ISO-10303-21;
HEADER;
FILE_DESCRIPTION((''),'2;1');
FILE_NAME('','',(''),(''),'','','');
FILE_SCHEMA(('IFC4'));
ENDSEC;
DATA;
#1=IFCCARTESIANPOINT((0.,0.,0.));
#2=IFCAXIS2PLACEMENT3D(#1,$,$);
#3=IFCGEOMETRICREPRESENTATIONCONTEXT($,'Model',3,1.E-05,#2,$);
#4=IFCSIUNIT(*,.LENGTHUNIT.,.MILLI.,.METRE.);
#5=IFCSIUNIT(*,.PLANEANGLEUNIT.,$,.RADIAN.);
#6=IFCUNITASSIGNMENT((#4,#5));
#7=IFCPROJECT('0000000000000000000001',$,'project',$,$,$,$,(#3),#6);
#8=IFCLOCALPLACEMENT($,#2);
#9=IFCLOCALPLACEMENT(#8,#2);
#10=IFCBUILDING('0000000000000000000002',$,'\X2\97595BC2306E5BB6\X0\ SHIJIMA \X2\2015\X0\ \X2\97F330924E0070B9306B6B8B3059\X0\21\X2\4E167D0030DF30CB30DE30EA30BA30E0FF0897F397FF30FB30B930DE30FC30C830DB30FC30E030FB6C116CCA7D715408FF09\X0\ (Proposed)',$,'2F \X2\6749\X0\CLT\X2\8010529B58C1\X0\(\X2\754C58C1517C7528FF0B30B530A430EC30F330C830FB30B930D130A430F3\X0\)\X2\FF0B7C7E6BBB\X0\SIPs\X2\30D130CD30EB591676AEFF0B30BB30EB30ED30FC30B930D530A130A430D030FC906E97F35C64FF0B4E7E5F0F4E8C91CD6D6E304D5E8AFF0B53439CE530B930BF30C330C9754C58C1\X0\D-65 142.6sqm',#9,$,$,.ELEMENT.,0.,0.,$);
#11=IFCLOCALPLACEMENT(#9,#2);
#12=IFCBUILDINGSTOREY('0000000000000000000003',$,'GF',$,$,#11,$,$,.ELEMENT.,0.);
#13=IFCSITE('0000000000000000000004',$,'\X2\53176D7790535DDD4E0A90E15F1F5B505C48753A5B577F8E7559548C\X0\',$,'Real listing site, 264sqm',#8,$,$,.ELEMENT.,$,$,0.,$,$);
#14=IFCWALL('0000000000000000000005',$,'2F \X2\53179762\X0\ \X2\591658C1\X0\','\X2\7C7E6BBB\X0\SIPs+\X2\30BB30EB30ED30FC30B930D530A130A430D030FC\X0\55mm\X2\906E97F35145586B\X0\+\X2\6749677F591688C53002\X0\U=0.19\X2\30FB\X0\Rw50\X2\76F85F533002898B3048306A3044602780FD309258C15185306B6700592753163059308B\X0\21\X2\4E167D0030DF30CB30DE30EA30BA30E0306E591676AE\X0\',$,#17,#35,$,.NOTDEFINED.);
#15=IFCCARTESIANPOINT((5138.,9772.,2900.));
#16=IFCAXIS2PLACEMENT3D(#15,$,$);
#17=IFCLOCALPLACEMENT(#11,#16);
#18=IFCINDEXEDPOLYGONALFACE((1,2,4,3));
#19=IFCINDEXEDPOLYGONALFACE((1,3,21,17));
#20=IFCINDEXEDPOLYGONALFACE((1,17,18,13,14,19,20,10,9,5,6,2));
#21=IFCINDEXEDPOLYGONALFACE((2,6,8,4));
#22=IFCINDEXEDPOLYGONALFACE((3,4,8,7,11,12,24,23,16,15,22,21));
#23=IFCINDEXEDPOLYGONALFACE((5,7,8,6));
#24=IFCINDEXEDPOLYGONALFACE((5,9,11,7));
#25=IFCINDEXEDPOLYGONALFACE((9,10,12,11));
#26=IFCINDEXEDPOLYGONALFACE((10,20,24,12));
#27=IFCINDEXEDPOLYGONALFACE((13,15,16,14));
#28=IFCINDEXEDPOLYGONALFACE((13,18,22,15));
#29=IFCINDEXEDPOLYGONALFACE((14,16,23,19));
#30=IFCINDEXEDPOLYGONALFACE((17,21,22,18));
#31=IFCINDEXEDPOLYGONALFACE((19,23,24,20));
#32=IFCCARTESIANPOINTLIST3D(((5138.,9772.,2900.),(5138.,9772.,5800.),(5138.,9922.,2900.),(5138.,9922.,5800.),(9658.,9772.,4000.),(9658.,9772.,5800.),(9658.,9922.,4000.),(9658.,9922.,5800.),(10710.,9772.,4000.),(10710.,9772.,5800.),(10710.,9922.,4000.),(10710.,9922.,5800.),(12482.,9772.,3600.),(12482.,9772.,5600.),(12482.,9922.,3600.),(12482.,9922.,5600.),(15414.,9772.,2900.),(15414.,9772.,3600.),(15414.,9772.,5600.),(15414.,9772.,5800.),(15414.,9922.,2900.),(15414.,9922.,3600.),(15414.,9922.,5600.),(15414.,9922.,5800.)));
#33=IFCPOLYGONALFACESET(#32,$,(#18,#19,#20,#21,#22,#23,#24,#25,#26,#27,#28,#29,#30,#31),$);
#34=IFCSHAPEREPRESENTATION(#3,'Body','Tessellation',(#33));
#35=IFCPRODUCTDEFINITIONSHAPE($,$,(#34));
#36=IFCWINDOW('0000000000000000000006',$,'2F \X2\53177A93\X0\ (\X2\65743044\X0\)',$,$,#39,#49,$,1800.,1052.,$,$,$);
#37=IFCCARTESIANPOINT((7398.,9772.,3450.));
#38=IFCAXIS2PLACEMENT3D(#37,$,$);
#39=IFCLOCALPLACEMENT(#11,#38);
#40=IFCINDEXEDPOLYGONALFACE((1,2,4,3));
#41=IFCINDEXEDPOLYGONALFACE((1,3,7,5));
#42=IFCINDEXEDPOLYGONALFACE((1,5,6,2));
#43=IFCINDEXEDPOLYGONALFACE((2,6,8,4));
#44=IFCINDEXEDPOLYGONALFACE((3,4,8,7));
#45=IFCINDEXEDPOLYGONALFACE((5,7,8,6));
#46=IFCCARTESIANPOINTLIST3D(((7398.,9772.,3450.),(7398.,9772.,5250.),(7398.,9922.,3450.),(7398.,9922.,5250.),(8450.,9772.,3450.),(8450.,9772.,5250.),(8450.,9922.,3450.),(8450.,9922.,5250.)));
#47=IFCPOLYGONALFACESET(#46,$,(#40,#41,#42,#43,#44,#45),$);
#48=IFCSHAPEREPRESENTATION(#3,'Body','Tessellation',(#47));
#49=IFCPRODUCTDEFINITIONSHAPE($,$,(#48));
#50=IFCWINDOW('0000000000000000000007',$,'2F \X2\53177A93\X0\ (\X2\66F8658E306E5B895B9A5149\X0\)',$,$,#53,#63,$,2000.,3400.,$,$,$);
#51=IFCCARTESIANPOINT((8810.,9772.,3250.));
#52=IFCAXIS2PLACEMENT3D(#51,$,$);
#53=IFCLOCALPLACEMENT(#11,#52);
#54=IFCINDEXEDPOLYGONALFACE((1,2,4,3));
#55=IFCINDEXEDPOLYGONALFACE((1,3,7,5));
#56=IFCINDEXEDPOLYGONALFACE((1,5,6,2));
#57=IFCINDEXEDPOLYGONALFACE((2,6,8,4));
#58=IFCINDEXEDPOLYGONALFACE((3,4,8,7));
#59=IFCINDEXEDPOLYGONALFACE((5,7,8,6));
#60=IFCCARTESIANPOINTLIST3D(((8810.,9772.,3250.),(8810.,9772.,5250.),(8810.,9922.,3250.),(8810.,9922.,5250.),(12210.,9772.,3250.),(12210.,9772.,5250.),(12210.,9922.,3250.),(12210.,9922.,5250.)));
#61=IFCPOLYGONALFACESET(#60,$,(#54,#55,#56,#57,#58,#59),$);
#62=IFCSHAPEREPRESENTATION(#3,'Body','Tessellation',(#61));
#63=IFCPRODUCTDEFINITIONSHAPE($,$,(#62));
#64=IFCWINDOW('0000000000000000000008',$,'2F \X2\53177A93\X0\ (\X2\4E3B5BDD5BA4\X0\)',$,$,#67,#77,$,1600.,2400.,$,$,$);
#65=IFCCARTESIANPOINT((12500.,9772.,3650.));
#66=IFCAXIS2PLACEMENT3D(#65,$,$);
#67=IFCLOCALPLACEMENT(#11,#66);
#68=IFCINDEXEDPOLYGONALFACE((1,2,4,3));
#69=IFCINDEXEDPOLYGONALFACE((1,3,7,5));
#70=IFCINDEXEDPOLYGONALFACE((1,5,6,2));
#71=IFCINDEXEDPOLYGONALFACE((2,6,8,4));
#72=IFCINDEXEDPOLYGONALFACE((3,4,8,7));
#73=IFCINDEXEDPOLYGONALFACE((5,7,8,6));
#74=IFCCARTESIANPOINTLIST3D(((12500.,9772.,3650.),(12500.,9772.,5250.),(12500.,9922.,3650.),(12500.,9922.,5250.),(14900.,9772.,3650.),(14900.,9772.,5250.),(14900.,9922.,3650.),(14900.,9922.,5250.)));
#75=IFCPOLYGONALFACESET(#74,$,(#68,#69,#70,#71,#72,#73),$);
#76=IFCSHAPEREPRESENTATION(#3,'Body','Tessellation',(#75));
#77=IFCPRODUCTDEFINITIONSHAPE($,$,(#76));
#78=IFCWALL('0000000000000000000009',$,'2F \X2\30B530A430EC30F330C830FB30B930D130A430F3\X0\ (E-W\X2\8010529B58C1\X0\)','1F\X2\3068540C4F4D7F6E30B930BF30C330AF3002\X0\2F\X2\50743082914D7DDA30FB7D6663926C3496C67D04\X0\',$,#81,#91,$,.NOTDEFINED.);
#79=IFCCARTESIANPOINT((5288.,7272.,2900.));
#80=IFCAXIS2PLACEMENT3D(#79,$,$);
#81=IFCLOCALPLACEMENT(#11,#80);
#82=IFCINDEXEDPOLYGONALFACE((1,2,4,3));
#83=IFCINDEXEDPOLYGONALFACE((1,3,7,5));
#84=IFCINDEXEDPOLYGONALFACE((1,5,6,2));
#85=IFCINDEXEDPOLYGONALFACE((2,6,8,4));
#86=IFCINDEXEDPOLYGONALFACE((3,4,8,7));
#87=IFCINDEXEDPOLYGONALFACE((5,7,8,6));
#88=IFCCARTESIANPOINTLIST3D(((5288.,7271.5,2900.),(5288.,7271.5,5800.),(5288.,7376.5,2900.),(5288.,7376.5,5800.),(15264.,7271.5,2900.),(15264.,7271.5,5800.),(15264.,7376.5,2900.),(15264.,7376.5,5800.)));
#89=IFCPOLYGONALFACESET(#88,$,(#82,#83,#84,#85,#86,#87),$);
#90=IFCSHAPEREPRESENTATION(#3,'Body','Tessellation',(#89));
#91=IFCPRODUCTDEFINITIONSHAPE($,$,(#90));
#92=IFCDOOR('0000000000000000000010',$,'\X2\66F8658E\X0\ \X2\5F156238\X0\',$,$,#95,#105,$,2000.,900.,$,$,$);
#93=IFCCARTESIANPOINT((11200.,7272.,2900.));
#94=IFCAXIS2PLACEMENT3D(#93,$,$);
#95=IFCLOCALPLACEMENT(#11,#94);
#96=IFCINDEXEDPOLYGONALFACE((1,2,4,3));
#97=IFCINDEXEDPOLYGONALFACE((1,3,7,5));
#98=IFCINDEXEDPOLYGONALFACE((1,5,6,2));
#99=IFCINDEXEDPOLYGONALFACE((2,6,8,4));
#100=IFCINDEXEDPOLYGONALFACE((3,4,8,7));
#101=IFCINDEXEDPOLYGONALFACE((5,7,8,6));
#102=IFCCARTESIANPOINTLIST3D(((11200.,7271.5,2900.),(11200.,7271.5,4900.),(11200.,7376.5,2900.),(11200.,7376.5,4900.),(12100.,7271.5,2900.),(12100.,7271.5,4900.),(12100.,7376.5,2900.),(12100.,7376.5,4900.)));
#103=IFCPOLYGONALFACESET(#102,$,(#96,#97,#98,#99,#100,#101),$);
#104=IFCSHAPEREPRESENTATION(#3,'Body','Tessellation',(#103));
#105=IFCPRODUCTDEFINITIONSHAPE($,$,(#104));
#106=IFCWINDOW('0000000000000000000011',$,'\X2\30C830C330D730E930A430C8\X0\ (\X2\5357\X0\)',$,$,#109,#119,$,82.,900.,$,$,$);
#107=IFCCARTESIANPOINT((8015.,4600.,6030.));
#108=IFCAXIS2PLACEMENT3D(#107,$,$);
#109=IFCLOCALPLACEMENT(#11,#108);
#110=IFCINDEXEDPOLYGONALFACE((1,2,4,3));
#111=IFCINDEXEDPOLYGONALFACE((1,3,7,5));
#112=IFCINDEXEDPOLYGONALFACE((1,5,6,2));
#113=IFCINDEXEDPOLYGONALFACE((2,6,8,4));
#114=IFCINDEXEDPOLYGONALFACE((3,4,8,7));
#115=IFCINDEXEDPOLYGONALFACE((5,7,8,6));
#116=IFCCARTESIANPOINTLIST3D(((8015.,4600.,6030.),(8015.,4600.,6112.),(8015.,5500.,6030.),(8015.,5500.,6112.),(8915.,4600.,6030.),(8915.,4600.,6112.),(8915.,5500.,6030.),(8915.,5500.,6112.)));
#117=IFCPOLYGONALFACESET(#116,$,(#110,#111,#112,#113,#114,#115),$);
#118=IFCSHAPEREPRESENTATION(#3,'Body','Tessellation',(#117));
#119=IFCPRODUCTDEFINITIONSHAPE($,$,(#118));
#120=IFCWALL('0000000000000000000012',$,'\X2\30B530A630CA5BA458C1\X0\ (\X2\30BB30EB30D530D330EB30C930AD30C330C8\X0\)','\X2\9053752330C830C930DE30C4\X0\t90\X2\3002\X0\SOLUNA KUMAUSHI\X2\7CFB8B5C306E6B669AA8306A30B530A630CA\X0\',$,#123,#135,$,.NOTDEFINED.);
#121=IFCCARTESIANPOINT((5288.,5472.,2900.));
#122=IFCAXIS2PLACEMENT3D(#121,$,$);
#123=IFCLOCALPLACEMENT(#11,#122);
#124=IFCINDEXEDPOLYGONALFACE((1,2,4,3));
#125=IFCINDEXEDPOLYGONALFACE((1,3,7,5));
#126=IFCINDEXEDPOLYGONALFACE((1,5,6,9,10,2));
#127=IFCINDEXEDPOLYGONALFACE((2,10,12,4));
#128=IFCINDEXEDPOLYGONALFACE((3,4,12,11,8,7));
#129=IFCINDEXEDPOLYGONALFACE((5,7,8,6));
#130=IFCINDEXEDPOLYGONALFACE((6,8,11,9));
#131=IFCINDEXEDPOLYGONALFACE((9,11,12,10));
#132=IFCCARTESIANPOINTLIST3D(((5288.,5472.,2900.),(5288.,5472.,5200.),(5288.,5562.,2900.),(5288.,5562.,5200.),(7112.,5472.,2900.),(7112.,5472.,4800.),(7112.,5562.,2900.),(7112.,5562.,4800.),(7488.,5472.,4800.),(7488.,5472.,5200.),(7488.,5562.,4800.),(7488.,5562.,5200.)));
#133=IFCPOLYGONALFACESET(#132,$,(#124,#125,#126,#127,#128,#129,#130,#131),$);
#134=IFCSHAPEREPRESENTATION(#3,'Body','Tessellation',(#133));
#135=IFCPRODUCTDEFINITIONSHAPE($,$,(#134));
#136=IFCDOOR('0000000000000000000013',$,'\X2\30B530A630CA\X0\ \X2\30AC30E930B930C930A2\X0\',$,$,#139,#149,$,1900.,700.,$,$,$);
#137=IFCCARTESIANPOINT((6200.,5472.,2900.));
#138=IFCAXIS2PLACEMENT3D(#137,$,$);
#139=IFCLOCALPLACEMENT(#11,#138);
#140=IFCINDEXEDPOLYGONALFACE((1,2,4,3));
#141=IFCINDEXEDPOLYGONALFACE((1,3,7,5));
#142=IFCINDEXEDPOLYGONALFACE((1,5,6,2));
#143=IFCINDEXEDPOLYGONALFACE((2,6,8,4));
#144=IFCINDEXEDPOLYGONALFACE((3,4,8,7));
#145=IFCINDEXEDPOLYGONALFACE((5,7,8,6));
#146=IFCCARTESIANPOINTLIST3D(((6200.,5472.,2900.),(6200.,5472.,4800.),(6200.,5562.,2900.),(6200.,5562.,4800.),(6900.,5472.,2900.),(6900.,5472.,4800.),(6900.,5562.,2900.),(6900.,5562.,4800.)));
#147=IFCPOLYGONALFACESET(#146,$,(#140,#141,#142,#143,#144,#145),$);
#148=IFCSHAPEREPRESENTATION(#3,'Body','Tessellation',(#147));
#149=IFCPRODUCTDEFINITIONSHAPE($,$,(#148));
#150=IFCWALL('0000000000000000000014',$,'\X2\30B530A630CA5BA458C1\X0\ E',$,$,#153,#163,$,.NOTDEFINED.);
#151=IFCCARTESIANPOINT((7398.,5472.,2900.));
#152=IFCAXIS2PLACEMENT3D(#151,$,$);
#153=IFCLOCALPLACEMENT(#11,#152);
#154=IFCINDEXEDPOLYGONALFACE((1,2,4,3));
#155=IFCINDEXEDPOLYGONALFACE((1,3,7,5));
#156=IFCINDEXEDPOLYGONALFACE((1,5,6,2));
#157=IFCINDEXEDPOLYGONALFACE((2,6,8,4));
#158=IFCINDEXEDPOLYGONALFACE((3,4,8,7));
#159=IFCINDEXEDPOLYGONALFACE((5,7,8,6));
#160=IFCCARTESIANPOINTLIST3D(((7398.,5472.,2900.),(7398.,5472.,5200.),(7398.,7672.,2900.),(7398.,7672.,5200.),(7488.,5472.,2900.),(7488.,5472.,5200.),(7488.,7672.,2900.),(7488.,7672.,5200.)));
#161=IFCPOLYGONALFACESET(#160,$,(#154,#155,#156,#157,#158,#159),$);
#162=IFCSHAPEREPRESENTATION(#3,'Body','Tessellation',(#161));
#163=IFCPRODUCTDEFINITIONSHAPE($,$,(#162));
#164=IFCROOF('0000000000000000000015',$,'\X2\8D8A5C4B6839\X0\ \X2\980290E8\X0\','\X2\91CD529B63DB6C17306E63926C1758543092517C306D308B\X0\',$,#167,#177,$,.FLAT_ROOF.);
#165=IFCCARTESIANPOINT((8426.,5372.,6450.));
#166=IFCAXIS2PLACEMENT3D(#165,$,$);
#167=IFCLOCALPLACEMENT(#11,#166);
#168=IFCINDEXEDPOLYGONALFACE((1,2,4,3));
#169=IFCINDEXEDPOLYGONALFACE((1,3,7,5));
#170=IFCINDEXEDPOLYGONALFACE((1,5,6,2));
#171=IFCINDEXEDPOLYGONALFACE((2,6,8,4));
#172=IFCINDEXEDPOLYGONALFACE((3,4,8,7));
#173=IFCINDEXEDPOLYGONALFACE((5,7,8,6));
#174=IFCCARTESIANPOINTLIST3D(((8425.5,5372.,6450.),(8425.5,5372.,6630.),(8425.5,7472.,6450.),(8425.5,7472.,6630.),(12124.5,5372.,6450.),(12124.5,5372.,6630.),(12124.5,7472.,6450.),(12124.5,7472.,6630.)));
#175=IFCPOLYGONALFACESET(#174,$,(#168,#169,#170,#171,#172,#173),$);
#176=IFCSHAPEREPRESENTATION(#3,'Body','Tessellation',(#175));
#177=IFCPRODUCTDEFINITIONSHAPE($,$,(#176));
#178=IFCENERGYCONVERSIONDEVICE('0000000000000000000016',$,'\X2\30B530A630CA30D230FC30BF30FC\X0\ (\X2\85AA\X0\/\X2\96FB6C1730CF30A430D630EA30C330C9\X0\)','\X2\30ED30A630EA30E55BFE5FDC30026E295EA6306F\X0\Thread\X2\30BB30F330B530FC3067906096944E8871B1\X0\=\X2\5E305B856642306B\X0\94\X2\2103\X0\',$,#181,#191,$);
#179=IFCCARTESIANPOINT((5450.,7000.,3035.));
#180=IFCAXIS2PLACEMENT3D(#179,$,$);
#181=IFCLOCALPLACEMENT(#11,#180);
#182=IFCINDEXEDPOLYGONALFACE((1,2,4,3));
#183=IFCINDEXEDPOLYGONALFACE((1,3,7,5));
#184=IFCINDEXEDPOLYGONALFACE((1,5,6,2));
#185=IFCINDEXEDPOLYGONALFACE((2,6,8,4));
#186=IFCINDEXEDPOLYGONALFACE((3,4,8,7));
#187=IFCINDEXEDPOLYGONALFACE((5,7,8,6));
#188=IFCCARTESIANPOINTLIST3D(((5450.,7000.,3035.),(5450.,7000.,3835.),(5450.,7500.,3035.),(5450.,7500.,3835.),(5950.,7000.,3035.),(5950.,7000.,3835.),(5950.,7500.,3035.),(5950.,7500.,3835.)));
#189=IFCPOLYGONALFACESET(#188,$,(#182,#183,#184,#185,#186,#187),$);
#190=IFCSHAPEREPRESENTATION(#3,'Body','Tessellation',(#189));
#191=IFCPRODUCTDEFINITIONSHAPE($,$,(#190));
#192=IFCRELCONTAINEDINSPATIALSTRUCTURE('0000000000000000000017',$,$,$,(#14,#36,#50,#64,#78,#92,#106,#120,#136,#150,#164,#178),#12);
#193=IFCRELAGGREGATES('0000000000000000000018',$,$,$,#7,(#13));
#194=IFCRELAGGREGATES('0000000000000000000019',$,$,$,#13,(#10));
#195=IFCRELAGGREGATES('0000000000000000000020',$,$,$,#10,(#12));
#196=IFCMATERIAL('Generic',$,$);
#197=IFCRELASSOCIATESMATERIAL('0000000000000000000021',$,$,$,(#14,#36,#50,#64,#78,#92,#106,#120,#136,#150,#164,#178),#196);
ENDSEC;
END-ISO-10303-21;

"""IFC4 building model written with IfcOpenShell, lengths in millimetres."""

from ifc_helpers import new_model, si_unit, frame, frame_2d, origin, place, context, project, spatial, rectangle, extrude, material, element, fill, save


model = new_model("IFC4")

# Units and contexts
model_context = context("Model", 3, precision=1e-05, world=origin())
ifc_project = project(units=[si_unit("LENGTHUNIT", "METRE", prefix="MILLI"), si_unit("PLANEANGLEUNIT", "RADIAN")], contexts=[model_context])

# Site, building, storey
site_placement = place(None, origin())
site = spatial("IfcSite", under=ifc_project, at=site_placement, Name="北海道川上郡弟子屈町字美留和", ObjectType="Real listing site, 264sqm", CompositionType="ELEMENT", RefElevation=0.0)
building_placement = place(site_placement, origin())
building = spatial("IfcBuilding", under=site, at=building_placement, Name="静寂の家 SHIJIMA ― 音を一点に残す21世紀ミニマリズム（音響・スマートホーム・民泊統合） (Proposed)", ObjectType="2F 杉CLT耐力壁(界壁兼用＋サイレント・スパイン)＋籾殻SIPsパネル外皮＋セルロースファイバー遮音層＋乾式二重浮き床＋千鳥スタッド界壁D-65 142.6sqm", CompositionType="ELEMENT", ElevationOfRefHeight=0.0, ElevationOfTerrain=0.0)
storey_placement = place(building_placement, origin())
storey = spatial("IfcBuildingStorey", under=building, at=storey_placement, Name="GF", CompositionType="ELEMENT", Elevation=0.0)

# Wall, openings, windows
ifc_material = material(Name="Generic")
wall_1_placement = place(storey_placement, frame((5138.0, 9772.0, 2900.0)))
wall_1 = element("IfcWall", 1, at=wall_1_placement, inside=storey, material=ifc_material, Name="2F 北面 外壁", Description="籾殻SIPs+セルロースファイバー55mm遮音充填+杉板外装。U=0.19・Rw50相当。見えない性能を壁内に最大化する21世紀ミニマリズムの外皮", PredefinedType="NOTDEFINED", context=model_context, shape_type="SweptSolid", body=[
    extrude(rectangle(XDim=10276.0, YDim=150.0, at=frame_2d((5138.0, 75.0))), frame((5138.0, 9772.0, 2900.0)), (0.0, 0.0, 1.0), 2900.0),
])
opening_1_placement = place(storey_placement, frame((7398.0, 9772.0, 3450.0)))
opening_1 = element("IfcOpeningElement", 2, at=opening_1_placement, cuts=wall_1, PredefinedType="NOTDEFINED", context=model_context, shape_type="SweptSolid", body=[
    extrude(rectangle(XDim=1052.0, YDim=150.0, at=frame_2d((526.0, 75.0))), frame((7398.0, 9772.0, 3450.0)), (0.0, 0.0, 1.0), 1800.0),
])
opening_2_placement = place(storey_placement, frame((8810.0, 9772.0, 3250.0)))
opening_2 = element("IfcOpeningElement", 3, at=opening_2_placement, cuts=wall_1, PredefinedType="NOTDEFINED", context=model_context, shape_type="SweptSolid", body=[
    extrude(rectangle(XDim=3400.0, YDim=150.0, at=frame_2d((1700.0, 75.0))), frame((8810.0, 9772.0, 3250.0)), (0.0, 0.0, 1.0), 2000.0),
])
opening_3_placement = place(storey_placement, frame((12500.0, 9772.0, 3650.0)))
opening_3 = element("IfcOpeningElement", 4, at=opening_3_placement, cuts=wall_1, PredefinedType="NOTDEFINED", context=model_context, shape_type="SweptSolid", body=[
    extrude(rectangle(XDim=2400.0, YDim=150.0, at=frame_2d((1200.0, 75.0))), frame((12500.0, 9772.0, 3650.0)), (0.0, 0.0, 1.0), 1600.0),
])
window_1_placement = place(storey_placement, frame((7398.0, 9772.0, 3450.0)))
window_1 = element("IfcWindow", 5, at=window_1_placement, inside=storey, material=ifc_material, Name="2F 北窓 (整い)", OverallHeight=1800.0, OverallWidth=1052.0, context=model_context, shape_type="SweptSolid", body=[
    extrude(rectangle(XDim=1052.0, YDim=150.0, at=frame_2d((526.0, 75.0))), frame((7398.0, 9772.0, 3450.0)), (0.0, 0.0, 1.0), 1800.0),
])
fill(opening_1, window_1)
window_2_placement = place(storey_placement, frame((8810.0, 9772.0, 3250.0)))
window_2 = element("IfcWindow", 6, at=window_2_placement, inside=storey, material=ifc_material, Name="2F 北窓 (書斎の安定光)", OverallHeight=2000.0, OverallWidth=3400.0, context=model_context, shape_type="SweptSolid", body=[
    extrude(rectangle(XDim=3400.0, YDim=150.0, at=frame_2d((1700.0, 75.0))), frame((8810.0, 9772.0, 3250.0)), (0.0, 0.0, 1.0), 2000.0),
])
fill(opening_2, window_2)
window_3_placement = place(storey_placement, frame((12500.0, 9772.0, 3650.0)))
window_3 = element("IfcWindow", 7, at=window_3_placement, inside=storey, material=ifc_material, Name="2F 北窓 (主寝室)", OverallHeight=1600.0, OverallWidth=2400.0, context=model_context, shape_type="SweptSolid", body=[
    extrude(rectangle(XDim=2400.0, YDim=150.0, at=frame_2d((1200.0, 75.0))), frame((12500.0, 9772.0, 3650.0)), (0.0, 0.0, 1.0), 1600.0),
])
fill(opening_3, window_3)

# Wall, opening, door
wall_2_placement = place(storey_placement, frame((5288.0, 7272.0, 2900.0)))
wall_2 = element("IfcWall", 8, at=wall_2_placement, inside=storey, material=ifc_material, Name="2F サイレント・スパイン (E-W耐力壁)", Description="1Fと同位置スタック。2F側も配線・給排水集約", PredefinedType="NOTDEFINED", context=model_context, shape_type="SweptSolid", body=[
    extrude(rectangle(XDim=9976.0, YDim=105.0, at=frame_2d((4988.0, 52.0))), frame((5288.0, 7272.0, 2900.0)), (0.0, 0.0, 1.0), 2900.0),
])
opening_4_placement = place(storey_placement, frame((11200.0, 7272.0, 2900.0)))
opening_4 = element("IfcOpeningElement", 9, at=opening_4_placement, cuts=wall_2, PredefinedType="NOTDEFINED", context=model_context, shape_type="SweptSolid", body=[
    extrude(rectangle(XDim=900.0, YDim=105.0, at=frame_2d((450.0, 52.0))), frame((11200.0, 7272.0, 2900.0)), (0.0, 0.0, 1.0), 2000.0),
])
door_1_placement = place(storey_placement, frame((11200.0, 7272.0, 2900.0)))
door_1 = element("IfcDoor", 10, at=door_1_placement, inside=storey, material=ifc_material, Name="書斎 引戸", OverallHeight=2000.0, OverallWidth=900.0, context=model_context, shape_type="SweptSolid", body=[
    extrude(rectangle(XDim=900.0, YDim=105.0, at=frame_2d((450.0, 52.0))), frame((11200.0, 7272.0, 2900.0)), (0.0, 0.0, 1.0), 2000.0),
])
fill(opening_4, door_1)

# Window
window_4_placement = place(storey_placement, frame((8015.0, 4600.0, 6030.0)))
element("IfcWindow", 11, at=window_4_placement, inside=storey, material=ifc_material, Name="トップライト (南)", OverallHeight=82.0, OverallWidth=900.0, context=model_context, shape_type="SweptSolid", body=[
    extrude(rectangle(XDim=900.0, YDim=900.0, at=frame_2d((450.0, 450.0))), frame((8015.0, 4600.0, 6030.0)), (0.0, 0.0, 1.0), 82.0),
])

# Wall, opening, door
wall_3_placement = place(storey_placement, frame((5288.0, 5472.0, 2900.0)))
wall_3 = element("IfcWall", 12, at=wall_3_placement, inside=storey, material=ifc_material, Name="サウナ室壁 (セルフビルドキット)", Description="道産トドマツt90。SOLUNA KUMAUSHI系譜の武骨なサウナ", PredefinedType="NOTDEFINED", context=model_context, shape_type="SweptSolid", body=[
    extrude(rectangle(XDim=2200.0, YDim=90.0, at=frame_2d((1100.0, 45.0))), frame((5288.0, 5472.0, 2900.0)), (0.0, 0.0, 1.0), 2300.0),
])
opening_5_placement = place(storey_placement, frame((6200.0, 5472.0, 2900.0)))
opening_5 = element("IfcOpeningElement", 13, at=opening_5_placement, cuts=wall_3, PredefinedType="NOTDEFINED", context=model_context, shape_type="SweptSolid", body=[
    extrude(rectangle(XDim=700.0, YDim=90.0, at=frame_2d((350.0, 45.0))), frame((6200.0, 5472.0, 2900.0)), (0.0, 0.0, 1.0), 1900.0),
])
door_2_placement = place(storey_placement, frame((6200.0, 5472.0, 2900.0)))
door_2 = element("IfcDoor", 14, at=door_2_placement, inside=storey, material=ifc_material, Name="サウナ ガラスドア", OverallHeight=1900.0, OverallWidth=700.0, context=model_context, shape_type="SweptSolid", body=[
    extrude(rectangle(XDim=700.0, YDim=90.0, at=frame_2d((350.0, 45.0))), frame((6200.0, 5472.0, 2900.0)), (0.0, 0.0, 1.0), 1900.0),
])
fill(opening_5, door_2)

# Wall
wall_4_placement = place(storey_placement, frame((7398.0, 5472.0, 2900.0)))
element("IfcWall", 15, at=wall_4_placement, inside=storey, material=ifc_material, Name="サウナ室壁 E", PredefinedType="NOTDEFINED", context=model_context, shape_type="SweptSolid", body=[
    extrude(rectangle(XDim=90.0, YDim=2200.0, at=frame_2d((45.0, 1100.0))), frame((7398.0, 5472.0, 2900.0)), (0.0, 0.0, 1.0), 2300.0),
])

# Roof
roof_placement = place(storey_placement, frame((8426.0, 5372.0, 6450.0)))
element("IfcRoof", 16, at=roof_placement, inside=storey, material=ifc_material, Name="越屋根 頂部", Description="重力換気の排気塔を兼ねる", PredefinedType="FLAT_ROOF", context=model_context, shape_type="SweptSolid", body=[
    extrude(rectangle(XDim=3699.0, YDim=2100.0, at=frame_2d((1849.0, 1050.0))), frame((8426.0, 5372.0, 6450.0)), (0.0, 0.0, 1.0), 180.0),
])

# Energy conversion device
energy_conversion_device_placement = place(storey_placement, frame((5450.0, 7000.0, 3035.0)))
element("IfcEnergyConversionDevice", 17, at=energy_conversion_device_placement, inside=storey, material=ifc_material, Name="サウナヒーター (薪/電気ハイブリッド)", Description="ロウリュ対応。温度はThreadセンサーで遠隔予熱=帰宅時に94℃", context=model_context, shape_type="SweptSolid", body=[
    extrude(rectangle(XDim=500.0, YDim=500.0, at=frame_2d((250.0, 250.0))), frame((5450.0, 7000.0, 3035.0)), (0.0, 0.0, 1.0), 800.0),
])

save(model, "model.ifc")
